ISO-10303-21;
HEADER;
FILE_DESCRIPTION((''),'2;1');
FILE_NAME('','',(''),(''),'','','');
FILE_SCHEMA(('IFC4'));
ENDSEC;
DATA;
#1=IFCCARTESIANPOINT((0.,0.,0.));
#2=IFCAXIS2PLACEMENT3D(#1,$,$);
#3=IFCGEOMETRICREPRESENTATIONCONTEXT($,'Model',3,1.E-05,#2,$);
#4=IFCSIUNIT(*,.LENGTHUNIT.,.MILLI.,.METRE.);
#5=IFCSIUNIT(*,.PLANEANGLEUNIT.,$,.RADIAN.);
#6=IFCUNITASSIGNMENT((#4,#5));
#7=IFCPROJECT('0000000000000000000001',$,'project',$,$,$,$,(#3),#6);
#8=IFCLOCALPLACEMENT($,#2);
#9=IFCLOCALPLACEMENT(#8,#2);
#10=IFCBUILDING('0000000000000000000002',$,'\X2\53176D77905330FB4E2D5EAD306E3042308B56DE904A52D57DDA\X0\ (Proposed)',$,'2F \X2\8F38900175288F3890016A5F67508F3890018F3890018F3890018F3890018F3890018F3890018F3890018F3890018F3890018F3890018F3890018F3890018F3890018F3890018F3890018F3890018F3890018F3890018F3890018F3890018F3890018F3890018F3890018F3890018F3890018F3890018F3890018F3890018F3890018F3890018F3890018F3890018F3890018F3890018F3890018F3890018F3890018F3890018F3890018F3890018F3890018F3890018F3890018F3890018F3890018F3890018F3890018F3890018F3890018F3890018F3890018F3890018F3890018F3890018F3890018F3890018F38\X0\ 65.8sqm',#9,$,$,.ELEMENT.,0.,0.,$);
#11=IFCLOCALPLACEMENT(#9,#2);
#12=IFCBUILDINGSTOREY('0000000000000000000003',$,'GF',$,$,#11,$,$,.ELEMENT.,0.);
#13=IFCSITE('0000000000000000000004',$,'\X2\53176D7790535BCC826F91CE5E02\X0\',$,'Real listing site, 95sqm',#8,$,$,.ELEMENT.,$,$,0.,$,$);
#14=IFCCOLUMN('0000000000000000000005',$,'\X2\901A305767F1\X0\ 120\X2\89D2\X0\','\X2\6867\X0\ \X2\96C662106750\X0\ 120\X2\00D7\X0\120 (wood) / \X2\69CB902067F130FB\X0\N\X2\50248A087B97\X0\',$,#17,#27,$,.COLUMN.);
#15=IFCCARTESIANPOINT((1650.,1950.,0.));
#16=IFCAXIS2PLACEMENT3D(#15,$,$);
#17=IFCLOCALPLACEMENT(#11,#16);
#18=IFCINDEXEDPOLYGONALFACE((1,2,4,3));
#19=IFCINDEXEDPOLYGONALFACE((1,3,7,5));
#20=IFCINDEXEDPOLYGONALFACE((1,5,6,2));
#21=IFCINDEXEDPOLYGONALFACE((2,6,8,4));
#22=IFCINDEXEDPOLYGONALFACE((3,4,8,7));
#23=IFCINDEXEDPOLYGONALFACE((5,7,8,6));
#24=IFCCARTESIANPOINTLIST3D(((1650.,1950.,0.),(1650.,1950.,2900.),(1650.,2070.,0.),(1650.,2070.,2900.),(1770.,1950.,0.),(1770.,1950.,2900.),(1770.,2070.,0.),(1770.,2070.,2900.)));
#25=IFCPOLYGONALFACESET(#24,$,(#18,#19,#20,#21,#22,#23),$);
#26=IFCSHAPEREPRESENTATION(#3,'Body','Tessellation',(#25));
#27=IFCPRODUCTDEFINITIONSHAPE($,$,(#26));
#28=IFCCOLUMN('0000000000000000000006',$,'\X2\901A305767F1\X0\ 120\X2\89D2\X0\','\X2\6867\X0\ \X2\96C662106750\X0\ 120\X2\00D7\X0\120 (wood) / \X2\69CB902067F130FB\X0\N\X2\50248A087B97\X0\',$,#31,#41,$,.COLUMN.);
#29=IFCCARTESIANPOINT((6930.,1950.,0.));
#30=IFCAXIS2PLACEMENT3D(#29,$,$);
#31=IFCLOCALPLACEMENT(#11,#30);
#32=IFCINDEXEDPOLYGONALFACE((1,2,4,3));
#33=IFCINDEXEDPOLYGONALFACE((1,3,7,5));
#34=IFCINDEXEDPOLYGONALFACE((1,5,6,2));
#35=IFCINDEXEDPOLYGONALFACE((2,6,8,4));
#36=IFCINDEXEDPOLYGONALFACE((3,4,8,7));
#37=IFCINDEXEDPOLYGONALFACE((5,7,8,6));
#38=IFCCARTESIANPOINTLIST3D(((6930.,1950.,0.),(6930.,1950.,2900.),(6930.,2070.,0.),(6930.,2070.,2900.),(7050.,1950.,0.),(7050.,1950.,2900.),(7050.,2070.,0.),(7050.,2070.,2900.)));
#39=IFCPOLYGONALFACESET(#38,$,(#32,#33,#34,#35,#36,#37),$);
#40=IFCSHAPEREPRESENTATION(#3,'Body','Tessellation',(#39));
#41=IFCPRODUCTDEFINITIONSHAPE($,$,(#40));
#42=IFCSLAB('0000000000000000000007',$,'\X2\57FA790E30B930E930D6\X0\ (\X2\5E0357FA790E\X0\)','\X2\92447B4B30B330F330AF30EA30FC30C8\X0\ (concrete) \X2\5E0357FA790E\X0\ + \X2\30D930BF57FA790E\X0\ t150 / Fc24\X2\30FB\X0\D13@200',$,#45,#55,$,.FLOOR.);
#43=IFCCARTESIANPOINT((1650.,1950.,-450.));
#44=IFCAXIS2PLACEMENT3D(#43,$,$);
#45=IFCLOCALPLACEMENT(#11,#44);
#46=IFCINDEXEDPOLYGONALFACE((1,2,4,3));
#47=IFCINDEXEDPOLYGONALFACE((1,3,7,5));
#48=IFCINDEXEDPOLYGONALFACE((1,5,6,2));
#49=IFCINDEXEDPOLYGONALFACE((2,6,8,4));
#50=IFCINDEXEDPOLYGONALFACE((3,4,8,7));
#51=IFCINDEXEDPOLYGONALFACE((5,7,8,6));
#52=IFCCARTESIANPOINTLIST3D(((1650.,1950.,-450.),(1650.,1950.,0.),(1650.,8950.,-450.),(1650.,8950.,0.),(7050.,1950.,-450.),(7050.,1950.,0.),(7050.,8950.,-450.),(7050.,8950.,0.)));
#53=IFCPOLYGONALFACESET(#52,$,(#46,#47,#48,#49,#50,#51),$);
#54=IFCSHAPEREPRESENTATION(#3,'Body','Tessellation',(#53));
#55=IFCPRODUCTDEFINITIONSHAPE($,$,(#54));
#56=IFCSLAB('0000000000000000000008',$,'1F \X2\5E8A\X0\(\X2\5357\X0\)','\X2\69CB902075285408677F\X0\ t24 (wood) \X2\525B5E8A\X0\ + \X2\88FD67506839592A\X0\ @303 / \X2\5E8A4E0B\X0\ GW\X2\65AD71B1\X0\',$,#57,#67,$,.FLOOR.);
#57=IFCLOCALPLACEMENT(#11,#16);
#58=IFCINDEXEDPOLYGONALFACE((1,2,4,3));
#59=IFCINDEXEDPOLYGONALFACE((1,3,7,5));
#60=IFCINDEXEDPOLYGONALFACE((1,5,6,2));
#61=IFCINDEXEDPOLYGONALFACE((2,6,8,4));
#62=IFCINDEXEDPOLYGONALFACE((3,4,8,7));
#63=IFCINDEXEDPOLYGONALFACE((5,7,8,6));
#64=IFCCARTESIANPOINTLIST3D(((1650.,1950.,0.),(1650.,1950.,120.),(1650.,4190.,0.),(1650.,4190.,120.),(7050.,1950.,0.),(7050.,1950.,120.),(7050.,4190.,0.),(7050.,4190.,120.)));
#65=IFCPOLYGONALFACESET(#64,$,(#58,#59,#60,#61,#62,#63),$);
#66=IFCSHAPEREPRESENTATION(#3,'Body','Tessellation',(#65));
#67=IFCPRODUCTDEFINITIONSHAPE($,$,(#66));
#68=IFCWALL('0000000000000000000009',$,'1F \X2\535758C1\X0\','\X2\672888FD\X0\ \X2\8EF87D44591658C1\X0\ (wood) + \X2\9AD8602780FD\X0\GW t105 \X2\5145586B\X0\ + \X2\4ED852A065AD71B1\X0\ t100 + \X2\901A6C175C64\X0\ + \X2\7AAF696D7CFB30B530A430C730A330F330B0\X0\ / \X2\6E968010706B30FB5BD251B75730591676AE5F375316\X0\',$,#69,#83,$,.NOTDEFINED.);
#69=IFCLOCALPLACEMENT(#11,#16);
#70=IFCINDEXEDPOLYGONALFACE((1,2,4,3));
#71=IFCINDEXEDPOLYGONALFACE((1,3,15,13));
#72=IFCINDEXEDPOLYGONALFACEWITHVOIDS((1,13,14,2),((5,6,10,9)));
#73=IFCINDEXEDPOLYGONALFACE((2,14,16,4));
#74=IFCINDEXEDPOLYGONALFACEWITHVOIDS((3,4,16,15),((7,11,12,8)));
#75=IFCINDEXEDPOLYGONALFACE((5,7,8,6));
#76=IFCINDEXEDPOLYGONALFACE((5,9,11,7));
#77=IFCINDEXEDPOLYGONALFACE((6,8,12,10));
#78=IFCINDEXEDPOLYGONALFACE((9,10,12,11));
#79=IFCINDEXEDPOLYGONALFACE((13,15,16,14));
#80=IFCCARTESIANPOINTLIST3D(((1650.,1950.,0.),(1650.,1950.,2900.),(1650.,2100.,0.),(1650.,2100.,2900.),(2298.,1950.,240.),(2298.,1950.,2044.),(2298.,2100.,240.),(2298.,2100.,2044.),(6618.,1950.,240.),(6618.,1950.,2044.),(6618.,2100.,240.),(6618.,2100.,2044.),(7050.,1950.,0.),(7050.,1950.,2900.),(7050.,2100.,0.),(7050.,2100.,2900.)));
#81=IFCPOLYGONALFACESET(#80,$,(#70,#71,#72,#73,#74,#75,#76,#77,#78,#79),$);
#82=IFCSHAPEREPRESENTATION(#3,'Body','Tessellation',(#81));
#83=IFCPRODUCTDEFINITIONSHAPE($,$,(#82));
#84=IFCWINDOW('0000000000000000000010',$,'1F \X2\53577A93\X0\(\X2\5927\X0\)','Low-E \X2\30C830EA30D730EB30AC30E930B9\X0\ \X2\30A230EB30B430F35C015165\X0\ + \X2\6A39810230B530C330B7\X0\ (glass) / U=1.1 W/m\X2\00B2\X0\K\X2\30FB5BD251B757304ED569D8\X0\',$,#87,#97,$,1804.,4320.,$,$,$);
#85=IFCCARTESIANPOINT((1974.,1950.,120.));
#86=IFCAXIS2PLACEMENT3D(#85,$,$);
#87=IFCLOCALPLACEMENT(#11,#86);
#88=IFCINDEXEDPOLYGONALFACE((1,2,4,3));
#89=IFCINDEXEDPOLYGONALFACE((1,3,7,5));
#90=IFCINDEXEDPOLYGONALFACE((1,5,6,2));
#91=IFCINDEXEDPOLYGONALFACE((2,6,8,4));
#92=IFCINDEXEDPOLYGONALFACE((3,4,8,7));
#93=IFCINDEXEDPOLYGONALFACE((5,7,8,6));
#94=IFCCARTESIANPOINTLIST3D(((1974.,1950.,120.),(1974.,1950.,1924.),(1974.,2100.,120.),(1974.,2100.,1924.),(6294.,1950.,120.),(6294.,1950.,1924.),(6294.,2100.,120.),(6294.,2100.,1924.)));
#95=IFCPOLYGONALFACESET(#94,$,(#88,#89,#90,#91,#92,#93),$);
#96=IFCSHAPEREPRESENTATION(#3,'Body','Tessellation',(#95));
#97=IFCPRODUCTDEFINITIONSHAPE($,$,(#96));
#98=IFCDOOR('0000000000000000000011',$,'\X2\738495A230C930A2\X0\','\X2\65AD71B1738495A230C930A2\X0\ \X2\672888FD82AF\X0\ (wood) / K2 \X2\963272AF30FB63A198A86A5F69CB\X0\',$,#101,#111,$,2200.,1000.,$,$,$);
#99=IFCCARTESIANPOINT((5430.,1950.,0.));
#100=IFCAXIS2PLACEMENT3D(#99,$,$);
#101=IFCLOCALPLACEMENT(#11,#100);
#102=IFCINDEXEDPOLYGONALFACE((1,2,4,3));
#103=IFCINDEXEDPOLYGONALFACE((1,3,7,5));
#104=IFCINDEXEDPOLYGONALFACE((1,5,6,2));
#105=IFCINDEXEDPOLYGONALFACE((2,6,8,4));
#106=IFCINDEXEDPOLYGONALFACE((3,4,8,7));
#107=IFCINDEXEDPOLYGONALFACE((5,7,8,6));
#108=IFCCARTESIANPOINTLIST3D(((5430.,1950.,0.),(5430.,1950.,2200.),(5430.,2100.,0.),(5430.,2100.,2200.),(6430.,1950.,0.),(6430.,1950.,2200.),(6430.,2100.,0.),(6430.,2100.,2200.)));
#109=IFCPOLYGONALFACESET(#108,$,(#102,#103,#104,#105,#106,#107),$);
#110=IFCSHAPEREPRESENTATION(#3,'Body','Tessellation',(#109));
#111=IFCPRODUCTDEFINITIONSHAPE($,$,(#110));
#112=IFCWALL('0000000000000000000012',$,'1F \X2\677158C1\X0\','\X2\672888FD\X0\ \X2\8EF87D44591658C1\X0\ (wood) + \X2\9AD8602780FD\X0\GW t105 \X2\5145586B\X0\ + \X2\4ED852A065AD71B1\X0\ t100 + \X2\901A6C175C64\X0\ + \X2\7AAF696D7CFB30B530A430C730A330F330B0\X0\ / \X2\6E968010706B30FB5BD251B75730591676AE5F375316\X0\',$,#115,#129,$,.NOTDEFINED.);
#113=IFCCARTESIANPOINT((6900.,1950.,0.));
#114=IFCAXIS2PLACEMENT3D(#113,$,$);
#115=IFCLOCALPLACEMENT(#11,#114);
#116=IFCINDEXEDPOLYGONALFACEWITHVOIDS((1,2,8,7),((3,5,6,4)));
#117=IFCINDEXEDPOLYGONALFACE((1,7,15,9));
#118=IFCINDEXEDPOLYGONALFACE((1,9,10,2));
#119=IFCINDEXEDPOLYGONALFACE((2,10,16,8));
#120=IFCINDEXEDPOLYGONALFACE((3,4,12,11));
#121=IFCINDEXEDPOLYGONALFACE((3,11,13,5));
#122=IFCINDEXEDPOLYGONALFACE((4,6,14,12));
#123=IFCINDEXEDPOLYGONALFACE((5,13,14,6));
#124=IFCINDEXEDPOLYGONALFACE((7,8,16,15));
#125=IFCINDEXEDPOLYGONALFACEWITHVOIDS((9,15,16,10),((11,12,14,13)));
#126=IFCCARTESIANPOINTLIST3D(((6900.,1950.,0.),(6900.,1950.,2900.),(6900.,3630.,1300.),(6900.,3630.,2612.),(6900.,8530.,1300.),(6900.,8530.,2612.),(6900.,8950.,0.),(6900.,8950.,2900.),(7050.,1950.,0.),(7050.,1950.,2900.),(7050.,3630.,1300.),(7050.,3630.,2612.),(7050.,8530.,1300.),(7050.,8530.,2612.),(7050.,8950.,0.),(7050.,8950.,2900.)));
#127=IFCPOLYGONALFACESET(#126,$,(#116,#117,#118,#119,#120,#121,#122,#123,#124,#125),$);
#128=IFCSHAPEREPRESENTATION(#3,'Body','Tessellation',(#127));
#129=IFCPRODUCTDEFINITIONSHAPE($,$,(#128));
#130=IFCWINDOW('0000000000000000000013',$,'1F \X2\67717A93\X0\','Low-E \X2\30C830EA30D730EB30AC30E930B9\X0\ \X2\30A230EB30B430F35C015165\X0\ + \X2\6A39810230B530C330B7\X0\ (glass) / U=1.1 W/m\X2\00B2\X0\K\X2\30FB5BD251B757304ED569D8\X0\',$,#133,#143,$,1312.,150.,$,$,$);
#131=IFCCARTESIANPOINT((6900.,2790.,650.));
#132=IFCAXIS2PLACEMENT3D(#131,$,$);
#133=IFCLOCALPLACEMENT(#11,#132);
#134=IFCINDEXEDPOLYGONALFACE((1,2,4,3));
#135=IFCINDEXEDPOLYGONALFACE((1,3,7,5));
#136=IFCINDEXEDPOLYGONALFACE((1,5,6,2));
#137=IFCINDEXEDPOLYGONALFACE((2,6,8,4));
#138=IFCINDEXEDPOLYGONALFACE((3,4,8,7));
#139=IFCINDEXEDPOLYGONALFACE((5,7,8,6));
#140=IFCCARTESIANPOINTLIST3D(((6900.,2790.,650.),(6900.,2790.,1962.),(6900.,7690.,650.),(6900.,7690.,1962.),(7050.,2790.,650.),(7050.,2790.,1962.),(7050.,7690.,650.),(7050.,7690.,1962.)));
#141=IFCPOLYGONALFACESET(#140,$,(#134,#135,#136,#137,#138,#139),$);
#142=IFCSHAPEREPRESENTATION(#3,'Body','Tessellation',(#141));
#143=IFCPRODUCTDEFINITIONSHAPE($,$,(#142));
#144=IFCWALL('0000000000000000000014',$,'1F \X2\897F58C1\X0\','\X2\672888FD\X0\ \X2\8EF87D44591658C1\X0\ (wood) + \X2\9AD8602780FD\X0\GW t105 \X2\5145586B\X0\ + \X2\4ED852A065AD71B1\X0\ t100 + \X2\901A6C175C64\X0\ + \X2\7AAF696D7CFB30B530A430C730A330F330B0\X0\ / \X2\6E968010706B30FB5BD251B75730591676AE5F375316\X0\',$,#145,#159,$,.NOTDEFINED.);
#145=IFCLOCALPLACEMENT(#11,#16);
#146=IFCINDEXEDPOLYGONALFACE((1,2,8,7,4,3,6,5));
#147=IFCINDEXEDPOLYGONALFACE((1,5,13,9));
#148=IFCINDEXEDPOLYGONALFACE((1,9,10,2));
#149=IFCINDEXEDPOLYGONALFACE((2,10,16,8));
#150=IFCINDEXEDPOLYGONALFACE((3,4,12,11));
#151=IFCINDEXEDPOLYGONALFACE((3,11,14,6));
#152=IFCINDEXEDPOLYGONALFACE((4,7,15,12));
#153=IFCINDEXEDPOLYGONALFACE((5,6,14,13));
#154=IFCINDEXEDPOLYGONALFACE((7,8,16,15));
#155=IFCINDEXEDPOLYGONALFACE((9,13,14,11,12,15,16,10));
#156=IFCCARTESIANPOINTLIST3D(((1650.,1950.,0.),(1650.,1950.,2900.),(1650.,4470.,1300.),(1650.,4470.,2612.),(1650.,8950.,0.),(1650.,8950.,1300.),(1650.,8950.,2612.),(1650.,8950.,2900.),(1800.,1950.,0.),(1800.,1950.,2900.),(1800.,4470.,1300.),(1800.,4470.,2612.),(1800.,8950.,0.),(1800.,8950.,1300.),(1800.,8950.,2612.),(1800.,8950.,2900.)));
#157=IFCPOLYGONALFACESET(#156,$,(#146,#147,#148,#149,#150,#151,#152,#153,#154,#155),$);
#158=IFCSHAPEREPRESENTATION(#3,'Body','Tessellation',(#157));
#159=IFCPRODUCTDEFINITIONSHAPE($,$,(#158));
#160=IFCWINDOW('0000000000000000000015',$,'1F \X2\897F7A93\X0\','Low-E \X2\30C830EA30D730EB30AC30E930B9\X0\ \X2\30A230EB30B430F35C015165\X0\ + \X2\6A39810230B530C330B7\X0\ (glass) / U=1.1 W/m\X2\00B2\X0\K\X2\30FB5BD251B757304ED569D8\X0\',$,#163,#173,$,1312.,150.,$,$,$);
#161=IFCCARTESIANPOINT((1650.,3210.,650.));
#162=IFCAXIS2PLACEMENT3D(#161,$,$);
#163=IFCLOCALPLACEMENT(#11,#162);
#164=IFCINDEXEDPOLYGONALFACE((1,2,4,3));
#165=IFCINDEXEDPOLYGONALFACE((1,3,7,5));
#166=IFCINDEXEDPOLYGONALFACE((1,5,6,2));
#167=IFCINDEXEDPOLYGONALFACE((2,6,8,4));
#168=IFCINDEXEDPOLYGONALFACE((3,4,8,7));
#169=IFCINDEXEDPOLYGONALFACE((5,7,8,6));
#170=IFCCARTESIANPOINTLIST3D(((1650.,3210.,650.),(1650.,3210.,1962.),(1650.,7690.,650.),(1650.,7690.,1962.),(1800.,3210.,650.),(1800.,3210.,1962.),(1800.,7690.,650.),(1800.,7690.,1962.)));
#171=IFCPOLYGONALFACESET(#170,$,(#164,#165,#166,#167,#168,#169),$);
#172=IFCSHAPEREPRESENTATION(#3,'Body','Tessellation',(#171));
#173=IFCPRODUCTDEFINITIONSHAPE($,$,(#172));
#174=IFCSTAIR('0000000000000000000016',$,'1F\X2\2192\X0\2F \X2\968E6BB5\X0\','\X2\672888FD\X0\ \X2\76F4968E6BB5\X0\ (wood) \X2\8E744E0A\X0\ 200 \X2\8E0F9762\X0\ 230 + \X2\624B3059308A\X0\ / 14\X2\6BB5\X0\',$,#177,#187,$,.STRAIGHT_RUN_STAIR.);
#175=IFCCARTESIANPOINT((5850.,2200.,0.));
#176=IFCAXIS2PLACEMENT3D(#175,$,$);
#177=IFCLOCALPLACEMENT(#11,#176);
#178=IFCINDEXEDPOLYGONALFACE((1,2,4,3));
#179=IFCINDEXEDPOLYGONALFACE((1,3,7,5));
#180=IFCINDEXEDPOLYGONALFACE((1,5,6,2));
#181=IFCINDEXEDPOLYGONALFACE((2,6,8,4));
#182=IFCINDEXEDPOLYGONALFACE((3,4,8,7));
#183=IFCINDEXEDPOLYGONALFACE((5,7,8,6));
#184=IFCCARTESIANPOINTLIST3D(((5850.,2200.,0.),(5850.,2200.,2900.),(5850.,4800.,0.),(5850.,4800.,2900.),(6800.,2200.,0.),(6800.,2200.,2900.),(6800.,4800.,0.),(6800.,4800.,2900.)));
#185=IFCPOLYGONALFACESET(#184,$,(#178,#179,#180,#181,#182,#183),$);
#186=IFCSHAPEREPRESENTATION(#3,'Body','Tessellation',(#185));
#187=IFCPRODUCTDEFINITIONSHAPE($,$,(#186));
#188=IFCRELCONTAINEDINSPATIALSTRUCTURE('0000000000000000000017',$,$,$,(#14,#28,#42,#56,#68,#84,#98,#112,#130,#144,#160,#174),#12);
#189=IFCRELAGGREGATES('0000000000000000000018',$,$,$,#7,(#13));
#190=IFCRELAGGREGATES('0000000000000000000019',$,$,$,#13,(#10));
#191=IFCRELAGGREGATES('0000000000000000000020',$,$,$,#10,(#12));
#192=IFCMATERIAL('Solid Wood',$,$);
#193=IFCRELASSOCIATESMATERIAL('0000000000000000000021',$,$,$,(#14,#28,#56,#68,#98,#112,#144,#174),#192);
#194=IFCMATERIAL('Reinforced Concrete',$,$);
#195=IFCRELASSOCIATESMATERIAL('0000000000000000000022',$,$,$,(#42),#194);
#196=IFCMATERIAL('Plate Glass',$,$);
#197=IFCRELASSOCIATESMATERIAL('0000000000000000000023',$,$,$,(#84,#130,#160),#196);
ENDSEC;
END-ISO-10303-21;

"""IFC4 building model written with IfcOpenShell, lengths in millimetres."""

from ifc_helpers import new_model, si_unit, frame, frame_2d, origin, place, context, project, spatial, rectangle, extrude, material, element, fill, save


model = new_model("IFC4")

# Units and contexts
model_context = context("Model", 3, precision=1e-05, world=origin())
ifc_project = project(units=[si_unit("LENGTHUNIT", "METRE", prefix="MILLI"), si_unit("PLANEANGLEUNIT", "RADIAN")], contexts=[model_context])

# Site, building, storey
site_placement = place(None, origin())
site = spatial("IfcSite", under=ifc_project, at=site_placement, Name="北海道富良野市", ObjectType="Real listing site, 95sqm", CompositionType="ELEMENT", RefElevation=0.0)
building_placement = place(site_placement, origin())
building = spatial("IfcBuilding", under=site, at=building_placement, Name="北海道・中庭のある回遊動線 (Proposed)", ObjectType="2F 輸送用輸送機材輸送輸送輸送輸送輸送輸送輸送輸送輸送輸送輸送輸送輸送輸送輸送輸送輸送輸送輸送輸送輸送輸送輸送輸送輸送輸送輸送輸送輸送輸送輸送輸送輸送輸送輸送輸送輸送輸送輸送輸送輸送輸送輸送輸送輸送輸送輸送輸送輸送輸送輸送輸送輸送輸送輸送輸送輸 65.8sqm", CompositionType="ELEMENT", ElevationOfRefHeight=0.0, ElevationOfTerrain=0.0)
storey_placement = place(building_placement, origin())
storey = spatial("IfcBuildingStorey", under=building, at=storey_placement, Name="GF", CompositionType="ELEMENT", Elevation=0.0)

# Columns
ifc_material_1 = material(Name="Solid Wood")
column_1_placement = place(storey_placement, frame((1650.0, 1950.0, 0.0)))
element("IfcColumn", 1, at=column_1_placement, inside=storey, material=ifc_material_1, Name="通し柱 120角", Description="桧 集成材 120×120 (wood) / 構造柱・N値計算", PredefinedType="COLUMN", context=model_context, shape_type="SweptSolid", body=[
    extrude(rectangle(XDim=120.0, YDim=120.0, at=frame_2d((60.0, 60.0))), frame((1650.0, 1950.0, 0.0)), (0.0, 0.0, 1.0), 2900.0),
])
column_2_placement = place(storey_placement, frame((6930.0, 1950.0, 0.0)))
element("IfcColumn", 2, at=column_2_placement, inside=storey, material=ifc_material_1, Name="通し柱 120角", Description="桧 集成材 120×120 (wood) / 構造柱・N値計算", PredefinedType="COLUMN", context=model_context, shape_type="SweptSolid", body=[
    extrude(rectangle(XDim=120.0, YDim=120.0, at=frame_2d((60.0, 60.0))), frame((6930.0, 1950.0, 0.0)), (0.0, 0.0, 1.0), 2900.0),
])

# Slabs
ifc_material_2 = material(Name="Reinforced Concrete")
slab_1_placement = place(storey_placement, frame((1650.0, 1950.0, -450.0)))
element("IfcSlab", 3, at=slab_1_placement, inside=storey, material=ifc_material_2, Name="基礎スラブ (布基礎)", Description="鉄筋コンクリート (concrete) 布基礎 + ベタ基礎 t150 / Fc24・D13@200", PredefinedType="FLOOR", context=model_context, shape_type="SweptSolid", body=[
    extrude(rectangle(XDim=5400.0, YDim=7000.0, at=frame_2d((2700.0, 3500.0))), frame((1650.0, 1950.0, -450.0)), (0.0, 0.0, 1.0), 450.0),
])
slab_2_placement = place(storey_placement, frame((1650.0, 1950.0, 0.0)))
element("IfcSlab", 4, at=slab_2_placement, inside=storey, material=ifc_material_1, Name="1F 床(南)", Description="構造用合板 t24 (wood) 剛床 + 製材根太 @303 / 床下 GW断熱", PredefinedType="FLOOR", context=model_context, shape_type="SweptSolid", body=[
    extrude(rectangle(XDim=5400.0, YDim=2240.0, at=frame_2d((2700.0, 1120.0))), frame((1650.0, 1950.0, 0.0)), (0.0, 0.0, 1.0), 120.0),
])

# Wall, openings, window, door
wall_1_placement = place(storey_placement, frame((1650.0, 1950.0, 0.0)))
wall_1 = element("IfcWall", 5, at=wall_1_placement, inside=storey, material=ifc_material_1, Name="1F 南壁", Description="木製 軸組外壁 (wood) + 高性能GW t105 充填 + 付加断熱 t100 + 通気層 + 窯業系サイディング / 準耐火・寒冷地外皮強化", PredefinedType="NOTDEFINED", context=model_context, shape_type="SweptSolid", body=[
    extrude(rectangle(XDim=5400.0, YDim=150.0, at=frame_2d((2700.0, 75.0))), frame((1650.0, 1950.0, 0.0)), (0.0, 0.0, 1.0), 2900.0),
])
opening_1_placement = place(storey_placement, frame((1974.0, 1950.0, 120.0)))
opening_1 = element("IfcOpeningElement", 6, at=opening_1_placement, cuts=wall_1, PredefinedType="NOTDEFINED", context=model_context, shape_type="SweptSolid", body=[
    extrude(rectangle(XDim=4320.0, YDim=150.0, at=frame_2d((2160.0, 75.0))), frame((1974.0, 1950.0, 120.0)), (0.0, 0.0, 1.0), 1804.0),
])
opening_2_placement = place(storey_placement, frame((5430.0, 1950.0, 0.0)))
opening_2 = element("IfcOpeningElement", 7, at=opening_2_placement, cuts=wall_1, PredefinedType="NOTDEFINED", context=model_context, shape_type="SweptSolid", body=[
    extrude(rectangle(XDim=1000.0, YDim=150.0, at=frame_2d((500.0, 75.0))), frame((5430.0, 1950.0, 0.0)), (0.0, 0.0, 1.0), 2200.0),
])
ifc_material_3 = material(Name="Plate Glass")
window_1_placement = place(storey_placement, frame((1974.0, 1950.0, 120.0)))
window_1 = element("IfcWindow", 8, at=window_1_placement, inside=storey, material=ifc_material_3, Name="1F 南窓(大)", Description="Low-E トリプルガラス アルゴン封入 + 樹脂サッシ (glass) / U=1.1 W/m²K・寒冷地仕様", OverallHeight=1804.0, OverallWidth=4320.0, context=model_context, shape_type="SweptSolid", body=[
    extrude(rectangle(XDim=4320.0, YDim=150.0, at=frame_2d((2160.0, 75.0))), frame((1974.0, 1950.0, 120.0)), (0.0, 0.0, 1.0), 1804.0),
])
fill(opening_1, window_1)
door_placement = place(storey_placement, frame((5430.0, 1950.0, 0.0)))
door = element("IfcDoor", 9, at=door_placement, inside=storey, material=ifc_material_1, Name="玄関ドア", Description="断熱玄関ドア 木製芯 (wood) / K2 防犯・採風機構", OverallHeight=2200.0, OverallWidth=1000.0, context=model_context, shape_type="SweptSolid", body=[
    extrude(rectangle(XDim=1000.0, YDim=150.0, at=frame_2d((500.0, 75.0))), frame((5430.0, 1950.0, 0.0)), (0.0, 0.0, 1.0), 2200.0),
])
fill(opening_2, door)

# Walls, openings, windows
wall_2_placement = place(storey_placement, frame((6900.0, 1950.0, 0.0)))
wall_2 = element("IfcWall", 10, at=wall_2_placement, inside=storey, material=ifc_material_1, Name="1F 東壁", Description="木製 軸組外壁 (wood) + 高性能GW t105 充填 + 付加断熱 t100 + 通気層 + 窯業系サイディング / 準耐火・寒冷地外皮強化", PredefinedType="NOTDEFINED", context=model_context, shape_type="SweptSolid", body=[
    extrude(rectangle(XDim=150.0, YDim=7000.0, at=frame_2d((75.0, 3500.0))), frame((6900.0, 1950.0, 0.0)), (0.0, 0.0, 1.0), 2900.0),
])
opening_3_placement = place(storey_placement, frame((6900.0, 2790.0, 650.0)))
opening_3 = element("IfcOpeningElement", 11, at=opening_3_placement, cuts=wall_2, PredefinedType="NOTDEFINED", context=model_context, shape_type="SweptSolid", body=[
    extrude(rectangle(XDim=150.0, YDim=4900.0, at=frame_2d((75.0, 2450.0))), frame((6900.0, 2790.0, 650.0)), (0.0, 0.0, 1.0), 1312.0),
])
window_2_placement = place(storey_placement, frame((6900.0, 2790.0, 650.0)))
window_2 = element("IfcWindow", 12, at=window_2_placement, inside=storey, material=ifc_material_3, Name="1F 東窓", Description="Low-E トリプルガラス アルゴン封入 + 樹脂サッシ (glass) / U=1.1 W/m²K・寒冷地仕様", OverallHeight=1312.0, OverallWidth=150.0, context=model_context, shape_type="SweptSolid", body=[
    extrude(rectangle(XDim=150.0, YDim=4900.0, at=frame_2d((75.0, 2450.0))), frame((6900.0, 2790.0, 650.0)), (0.0, 0.0, 1.0), 1312.0),
])
fill(opening_3, window_2)
wall_3_placement = place(storey_placement, frame((1650.0, 1950.0, 0.0)))
wall_3 = element("IfcWall", 13, at=wall_3_placement, inside=storey, material=ifc_material_1, Name="1F 西壁", Description="木製 軸組外壁 (wood) + 高性能GW t105 充填 + 付加断熱 t100 + 通気層 + 窯業系サイディング / 準耐火・寒冷地外皮強化", PredefinedType="NOTDEFINED", context=model_context, shape_type="SweptSolid", body=[
    extrude(rectangle(XDim=150.0, YDim=7000.0, at=frame_2d((75.0, 3500.0))), frame((1650.0, 1950.0, 0.0)), (0.0, 0.0, 1.0), 2900.0),
])
opening_4_placement = place(storey_placement, frame((1650.0, 3210.0, 650.0)))
opening_4 = element("IfcOpeningElement", 14, at=opening_4_placement, cuts=wall_3, PredefinedType="NOTDEFINED", context=model_context, shape_type="SweptSolid", body=[
    extrude(rectangle(XDim=150.0, YDim=4480.0, at=frame_2d((75.0, 2240.0))), frame((1650.0, 3210.0, 650.0)), (0.0, 0.0, 1.0), 1312.0),
])
window_3_placement = place(storey_placement, frame((1650.0, 3210.0, 650.0)))
window_3 = element("IfcWindow", 15, at=window_3_placement, inside=storey, material=ifc_material_3, Name="1F 西窓", Description="Low-E トリプルガラス アルゴン封入 + 樹脂サッシ (glass) / U=1.1 W/m²K・寒冷地仕様", OverallHeight=1312.0, OverallWidth=150.0, context=model_context, shape_type="SweptSolid", body=[
    extrude(rectangle(XDim=150.0, YDim=4480.0, at=frame_2d((75.0, 2240.0))), frame((1650.0, 3210.0, 650.0)), (0.0, 0.0, 1.0), 1312.0),
])
fill(opening_4, window_3)

# Stair
stair_placement = place(storey_placement, frame((5850.0, 2200.0, 0.0)))
element("IfcStair", 16, at=stair_placement, inside=storey, material=ifc_material_1, Name="1F→2F 階段", Description="木製 直階段 (wood) 蹴上 200 踏面 230 + 手すり / 14段", PredefinedType="STRAIGHT_RUN_STAIR", context=model_context, shape_type="SweptSolid", body=[
    extrude(rectangle(XDim=950.0, YDim=2600.0, at=frame_2d((475.0, 1300.0))), frame((5850.0, 2200.0, 0.0)), (0.0, 0.0, 1.0), 2900.0),
])

save(model, "model.ifc")
